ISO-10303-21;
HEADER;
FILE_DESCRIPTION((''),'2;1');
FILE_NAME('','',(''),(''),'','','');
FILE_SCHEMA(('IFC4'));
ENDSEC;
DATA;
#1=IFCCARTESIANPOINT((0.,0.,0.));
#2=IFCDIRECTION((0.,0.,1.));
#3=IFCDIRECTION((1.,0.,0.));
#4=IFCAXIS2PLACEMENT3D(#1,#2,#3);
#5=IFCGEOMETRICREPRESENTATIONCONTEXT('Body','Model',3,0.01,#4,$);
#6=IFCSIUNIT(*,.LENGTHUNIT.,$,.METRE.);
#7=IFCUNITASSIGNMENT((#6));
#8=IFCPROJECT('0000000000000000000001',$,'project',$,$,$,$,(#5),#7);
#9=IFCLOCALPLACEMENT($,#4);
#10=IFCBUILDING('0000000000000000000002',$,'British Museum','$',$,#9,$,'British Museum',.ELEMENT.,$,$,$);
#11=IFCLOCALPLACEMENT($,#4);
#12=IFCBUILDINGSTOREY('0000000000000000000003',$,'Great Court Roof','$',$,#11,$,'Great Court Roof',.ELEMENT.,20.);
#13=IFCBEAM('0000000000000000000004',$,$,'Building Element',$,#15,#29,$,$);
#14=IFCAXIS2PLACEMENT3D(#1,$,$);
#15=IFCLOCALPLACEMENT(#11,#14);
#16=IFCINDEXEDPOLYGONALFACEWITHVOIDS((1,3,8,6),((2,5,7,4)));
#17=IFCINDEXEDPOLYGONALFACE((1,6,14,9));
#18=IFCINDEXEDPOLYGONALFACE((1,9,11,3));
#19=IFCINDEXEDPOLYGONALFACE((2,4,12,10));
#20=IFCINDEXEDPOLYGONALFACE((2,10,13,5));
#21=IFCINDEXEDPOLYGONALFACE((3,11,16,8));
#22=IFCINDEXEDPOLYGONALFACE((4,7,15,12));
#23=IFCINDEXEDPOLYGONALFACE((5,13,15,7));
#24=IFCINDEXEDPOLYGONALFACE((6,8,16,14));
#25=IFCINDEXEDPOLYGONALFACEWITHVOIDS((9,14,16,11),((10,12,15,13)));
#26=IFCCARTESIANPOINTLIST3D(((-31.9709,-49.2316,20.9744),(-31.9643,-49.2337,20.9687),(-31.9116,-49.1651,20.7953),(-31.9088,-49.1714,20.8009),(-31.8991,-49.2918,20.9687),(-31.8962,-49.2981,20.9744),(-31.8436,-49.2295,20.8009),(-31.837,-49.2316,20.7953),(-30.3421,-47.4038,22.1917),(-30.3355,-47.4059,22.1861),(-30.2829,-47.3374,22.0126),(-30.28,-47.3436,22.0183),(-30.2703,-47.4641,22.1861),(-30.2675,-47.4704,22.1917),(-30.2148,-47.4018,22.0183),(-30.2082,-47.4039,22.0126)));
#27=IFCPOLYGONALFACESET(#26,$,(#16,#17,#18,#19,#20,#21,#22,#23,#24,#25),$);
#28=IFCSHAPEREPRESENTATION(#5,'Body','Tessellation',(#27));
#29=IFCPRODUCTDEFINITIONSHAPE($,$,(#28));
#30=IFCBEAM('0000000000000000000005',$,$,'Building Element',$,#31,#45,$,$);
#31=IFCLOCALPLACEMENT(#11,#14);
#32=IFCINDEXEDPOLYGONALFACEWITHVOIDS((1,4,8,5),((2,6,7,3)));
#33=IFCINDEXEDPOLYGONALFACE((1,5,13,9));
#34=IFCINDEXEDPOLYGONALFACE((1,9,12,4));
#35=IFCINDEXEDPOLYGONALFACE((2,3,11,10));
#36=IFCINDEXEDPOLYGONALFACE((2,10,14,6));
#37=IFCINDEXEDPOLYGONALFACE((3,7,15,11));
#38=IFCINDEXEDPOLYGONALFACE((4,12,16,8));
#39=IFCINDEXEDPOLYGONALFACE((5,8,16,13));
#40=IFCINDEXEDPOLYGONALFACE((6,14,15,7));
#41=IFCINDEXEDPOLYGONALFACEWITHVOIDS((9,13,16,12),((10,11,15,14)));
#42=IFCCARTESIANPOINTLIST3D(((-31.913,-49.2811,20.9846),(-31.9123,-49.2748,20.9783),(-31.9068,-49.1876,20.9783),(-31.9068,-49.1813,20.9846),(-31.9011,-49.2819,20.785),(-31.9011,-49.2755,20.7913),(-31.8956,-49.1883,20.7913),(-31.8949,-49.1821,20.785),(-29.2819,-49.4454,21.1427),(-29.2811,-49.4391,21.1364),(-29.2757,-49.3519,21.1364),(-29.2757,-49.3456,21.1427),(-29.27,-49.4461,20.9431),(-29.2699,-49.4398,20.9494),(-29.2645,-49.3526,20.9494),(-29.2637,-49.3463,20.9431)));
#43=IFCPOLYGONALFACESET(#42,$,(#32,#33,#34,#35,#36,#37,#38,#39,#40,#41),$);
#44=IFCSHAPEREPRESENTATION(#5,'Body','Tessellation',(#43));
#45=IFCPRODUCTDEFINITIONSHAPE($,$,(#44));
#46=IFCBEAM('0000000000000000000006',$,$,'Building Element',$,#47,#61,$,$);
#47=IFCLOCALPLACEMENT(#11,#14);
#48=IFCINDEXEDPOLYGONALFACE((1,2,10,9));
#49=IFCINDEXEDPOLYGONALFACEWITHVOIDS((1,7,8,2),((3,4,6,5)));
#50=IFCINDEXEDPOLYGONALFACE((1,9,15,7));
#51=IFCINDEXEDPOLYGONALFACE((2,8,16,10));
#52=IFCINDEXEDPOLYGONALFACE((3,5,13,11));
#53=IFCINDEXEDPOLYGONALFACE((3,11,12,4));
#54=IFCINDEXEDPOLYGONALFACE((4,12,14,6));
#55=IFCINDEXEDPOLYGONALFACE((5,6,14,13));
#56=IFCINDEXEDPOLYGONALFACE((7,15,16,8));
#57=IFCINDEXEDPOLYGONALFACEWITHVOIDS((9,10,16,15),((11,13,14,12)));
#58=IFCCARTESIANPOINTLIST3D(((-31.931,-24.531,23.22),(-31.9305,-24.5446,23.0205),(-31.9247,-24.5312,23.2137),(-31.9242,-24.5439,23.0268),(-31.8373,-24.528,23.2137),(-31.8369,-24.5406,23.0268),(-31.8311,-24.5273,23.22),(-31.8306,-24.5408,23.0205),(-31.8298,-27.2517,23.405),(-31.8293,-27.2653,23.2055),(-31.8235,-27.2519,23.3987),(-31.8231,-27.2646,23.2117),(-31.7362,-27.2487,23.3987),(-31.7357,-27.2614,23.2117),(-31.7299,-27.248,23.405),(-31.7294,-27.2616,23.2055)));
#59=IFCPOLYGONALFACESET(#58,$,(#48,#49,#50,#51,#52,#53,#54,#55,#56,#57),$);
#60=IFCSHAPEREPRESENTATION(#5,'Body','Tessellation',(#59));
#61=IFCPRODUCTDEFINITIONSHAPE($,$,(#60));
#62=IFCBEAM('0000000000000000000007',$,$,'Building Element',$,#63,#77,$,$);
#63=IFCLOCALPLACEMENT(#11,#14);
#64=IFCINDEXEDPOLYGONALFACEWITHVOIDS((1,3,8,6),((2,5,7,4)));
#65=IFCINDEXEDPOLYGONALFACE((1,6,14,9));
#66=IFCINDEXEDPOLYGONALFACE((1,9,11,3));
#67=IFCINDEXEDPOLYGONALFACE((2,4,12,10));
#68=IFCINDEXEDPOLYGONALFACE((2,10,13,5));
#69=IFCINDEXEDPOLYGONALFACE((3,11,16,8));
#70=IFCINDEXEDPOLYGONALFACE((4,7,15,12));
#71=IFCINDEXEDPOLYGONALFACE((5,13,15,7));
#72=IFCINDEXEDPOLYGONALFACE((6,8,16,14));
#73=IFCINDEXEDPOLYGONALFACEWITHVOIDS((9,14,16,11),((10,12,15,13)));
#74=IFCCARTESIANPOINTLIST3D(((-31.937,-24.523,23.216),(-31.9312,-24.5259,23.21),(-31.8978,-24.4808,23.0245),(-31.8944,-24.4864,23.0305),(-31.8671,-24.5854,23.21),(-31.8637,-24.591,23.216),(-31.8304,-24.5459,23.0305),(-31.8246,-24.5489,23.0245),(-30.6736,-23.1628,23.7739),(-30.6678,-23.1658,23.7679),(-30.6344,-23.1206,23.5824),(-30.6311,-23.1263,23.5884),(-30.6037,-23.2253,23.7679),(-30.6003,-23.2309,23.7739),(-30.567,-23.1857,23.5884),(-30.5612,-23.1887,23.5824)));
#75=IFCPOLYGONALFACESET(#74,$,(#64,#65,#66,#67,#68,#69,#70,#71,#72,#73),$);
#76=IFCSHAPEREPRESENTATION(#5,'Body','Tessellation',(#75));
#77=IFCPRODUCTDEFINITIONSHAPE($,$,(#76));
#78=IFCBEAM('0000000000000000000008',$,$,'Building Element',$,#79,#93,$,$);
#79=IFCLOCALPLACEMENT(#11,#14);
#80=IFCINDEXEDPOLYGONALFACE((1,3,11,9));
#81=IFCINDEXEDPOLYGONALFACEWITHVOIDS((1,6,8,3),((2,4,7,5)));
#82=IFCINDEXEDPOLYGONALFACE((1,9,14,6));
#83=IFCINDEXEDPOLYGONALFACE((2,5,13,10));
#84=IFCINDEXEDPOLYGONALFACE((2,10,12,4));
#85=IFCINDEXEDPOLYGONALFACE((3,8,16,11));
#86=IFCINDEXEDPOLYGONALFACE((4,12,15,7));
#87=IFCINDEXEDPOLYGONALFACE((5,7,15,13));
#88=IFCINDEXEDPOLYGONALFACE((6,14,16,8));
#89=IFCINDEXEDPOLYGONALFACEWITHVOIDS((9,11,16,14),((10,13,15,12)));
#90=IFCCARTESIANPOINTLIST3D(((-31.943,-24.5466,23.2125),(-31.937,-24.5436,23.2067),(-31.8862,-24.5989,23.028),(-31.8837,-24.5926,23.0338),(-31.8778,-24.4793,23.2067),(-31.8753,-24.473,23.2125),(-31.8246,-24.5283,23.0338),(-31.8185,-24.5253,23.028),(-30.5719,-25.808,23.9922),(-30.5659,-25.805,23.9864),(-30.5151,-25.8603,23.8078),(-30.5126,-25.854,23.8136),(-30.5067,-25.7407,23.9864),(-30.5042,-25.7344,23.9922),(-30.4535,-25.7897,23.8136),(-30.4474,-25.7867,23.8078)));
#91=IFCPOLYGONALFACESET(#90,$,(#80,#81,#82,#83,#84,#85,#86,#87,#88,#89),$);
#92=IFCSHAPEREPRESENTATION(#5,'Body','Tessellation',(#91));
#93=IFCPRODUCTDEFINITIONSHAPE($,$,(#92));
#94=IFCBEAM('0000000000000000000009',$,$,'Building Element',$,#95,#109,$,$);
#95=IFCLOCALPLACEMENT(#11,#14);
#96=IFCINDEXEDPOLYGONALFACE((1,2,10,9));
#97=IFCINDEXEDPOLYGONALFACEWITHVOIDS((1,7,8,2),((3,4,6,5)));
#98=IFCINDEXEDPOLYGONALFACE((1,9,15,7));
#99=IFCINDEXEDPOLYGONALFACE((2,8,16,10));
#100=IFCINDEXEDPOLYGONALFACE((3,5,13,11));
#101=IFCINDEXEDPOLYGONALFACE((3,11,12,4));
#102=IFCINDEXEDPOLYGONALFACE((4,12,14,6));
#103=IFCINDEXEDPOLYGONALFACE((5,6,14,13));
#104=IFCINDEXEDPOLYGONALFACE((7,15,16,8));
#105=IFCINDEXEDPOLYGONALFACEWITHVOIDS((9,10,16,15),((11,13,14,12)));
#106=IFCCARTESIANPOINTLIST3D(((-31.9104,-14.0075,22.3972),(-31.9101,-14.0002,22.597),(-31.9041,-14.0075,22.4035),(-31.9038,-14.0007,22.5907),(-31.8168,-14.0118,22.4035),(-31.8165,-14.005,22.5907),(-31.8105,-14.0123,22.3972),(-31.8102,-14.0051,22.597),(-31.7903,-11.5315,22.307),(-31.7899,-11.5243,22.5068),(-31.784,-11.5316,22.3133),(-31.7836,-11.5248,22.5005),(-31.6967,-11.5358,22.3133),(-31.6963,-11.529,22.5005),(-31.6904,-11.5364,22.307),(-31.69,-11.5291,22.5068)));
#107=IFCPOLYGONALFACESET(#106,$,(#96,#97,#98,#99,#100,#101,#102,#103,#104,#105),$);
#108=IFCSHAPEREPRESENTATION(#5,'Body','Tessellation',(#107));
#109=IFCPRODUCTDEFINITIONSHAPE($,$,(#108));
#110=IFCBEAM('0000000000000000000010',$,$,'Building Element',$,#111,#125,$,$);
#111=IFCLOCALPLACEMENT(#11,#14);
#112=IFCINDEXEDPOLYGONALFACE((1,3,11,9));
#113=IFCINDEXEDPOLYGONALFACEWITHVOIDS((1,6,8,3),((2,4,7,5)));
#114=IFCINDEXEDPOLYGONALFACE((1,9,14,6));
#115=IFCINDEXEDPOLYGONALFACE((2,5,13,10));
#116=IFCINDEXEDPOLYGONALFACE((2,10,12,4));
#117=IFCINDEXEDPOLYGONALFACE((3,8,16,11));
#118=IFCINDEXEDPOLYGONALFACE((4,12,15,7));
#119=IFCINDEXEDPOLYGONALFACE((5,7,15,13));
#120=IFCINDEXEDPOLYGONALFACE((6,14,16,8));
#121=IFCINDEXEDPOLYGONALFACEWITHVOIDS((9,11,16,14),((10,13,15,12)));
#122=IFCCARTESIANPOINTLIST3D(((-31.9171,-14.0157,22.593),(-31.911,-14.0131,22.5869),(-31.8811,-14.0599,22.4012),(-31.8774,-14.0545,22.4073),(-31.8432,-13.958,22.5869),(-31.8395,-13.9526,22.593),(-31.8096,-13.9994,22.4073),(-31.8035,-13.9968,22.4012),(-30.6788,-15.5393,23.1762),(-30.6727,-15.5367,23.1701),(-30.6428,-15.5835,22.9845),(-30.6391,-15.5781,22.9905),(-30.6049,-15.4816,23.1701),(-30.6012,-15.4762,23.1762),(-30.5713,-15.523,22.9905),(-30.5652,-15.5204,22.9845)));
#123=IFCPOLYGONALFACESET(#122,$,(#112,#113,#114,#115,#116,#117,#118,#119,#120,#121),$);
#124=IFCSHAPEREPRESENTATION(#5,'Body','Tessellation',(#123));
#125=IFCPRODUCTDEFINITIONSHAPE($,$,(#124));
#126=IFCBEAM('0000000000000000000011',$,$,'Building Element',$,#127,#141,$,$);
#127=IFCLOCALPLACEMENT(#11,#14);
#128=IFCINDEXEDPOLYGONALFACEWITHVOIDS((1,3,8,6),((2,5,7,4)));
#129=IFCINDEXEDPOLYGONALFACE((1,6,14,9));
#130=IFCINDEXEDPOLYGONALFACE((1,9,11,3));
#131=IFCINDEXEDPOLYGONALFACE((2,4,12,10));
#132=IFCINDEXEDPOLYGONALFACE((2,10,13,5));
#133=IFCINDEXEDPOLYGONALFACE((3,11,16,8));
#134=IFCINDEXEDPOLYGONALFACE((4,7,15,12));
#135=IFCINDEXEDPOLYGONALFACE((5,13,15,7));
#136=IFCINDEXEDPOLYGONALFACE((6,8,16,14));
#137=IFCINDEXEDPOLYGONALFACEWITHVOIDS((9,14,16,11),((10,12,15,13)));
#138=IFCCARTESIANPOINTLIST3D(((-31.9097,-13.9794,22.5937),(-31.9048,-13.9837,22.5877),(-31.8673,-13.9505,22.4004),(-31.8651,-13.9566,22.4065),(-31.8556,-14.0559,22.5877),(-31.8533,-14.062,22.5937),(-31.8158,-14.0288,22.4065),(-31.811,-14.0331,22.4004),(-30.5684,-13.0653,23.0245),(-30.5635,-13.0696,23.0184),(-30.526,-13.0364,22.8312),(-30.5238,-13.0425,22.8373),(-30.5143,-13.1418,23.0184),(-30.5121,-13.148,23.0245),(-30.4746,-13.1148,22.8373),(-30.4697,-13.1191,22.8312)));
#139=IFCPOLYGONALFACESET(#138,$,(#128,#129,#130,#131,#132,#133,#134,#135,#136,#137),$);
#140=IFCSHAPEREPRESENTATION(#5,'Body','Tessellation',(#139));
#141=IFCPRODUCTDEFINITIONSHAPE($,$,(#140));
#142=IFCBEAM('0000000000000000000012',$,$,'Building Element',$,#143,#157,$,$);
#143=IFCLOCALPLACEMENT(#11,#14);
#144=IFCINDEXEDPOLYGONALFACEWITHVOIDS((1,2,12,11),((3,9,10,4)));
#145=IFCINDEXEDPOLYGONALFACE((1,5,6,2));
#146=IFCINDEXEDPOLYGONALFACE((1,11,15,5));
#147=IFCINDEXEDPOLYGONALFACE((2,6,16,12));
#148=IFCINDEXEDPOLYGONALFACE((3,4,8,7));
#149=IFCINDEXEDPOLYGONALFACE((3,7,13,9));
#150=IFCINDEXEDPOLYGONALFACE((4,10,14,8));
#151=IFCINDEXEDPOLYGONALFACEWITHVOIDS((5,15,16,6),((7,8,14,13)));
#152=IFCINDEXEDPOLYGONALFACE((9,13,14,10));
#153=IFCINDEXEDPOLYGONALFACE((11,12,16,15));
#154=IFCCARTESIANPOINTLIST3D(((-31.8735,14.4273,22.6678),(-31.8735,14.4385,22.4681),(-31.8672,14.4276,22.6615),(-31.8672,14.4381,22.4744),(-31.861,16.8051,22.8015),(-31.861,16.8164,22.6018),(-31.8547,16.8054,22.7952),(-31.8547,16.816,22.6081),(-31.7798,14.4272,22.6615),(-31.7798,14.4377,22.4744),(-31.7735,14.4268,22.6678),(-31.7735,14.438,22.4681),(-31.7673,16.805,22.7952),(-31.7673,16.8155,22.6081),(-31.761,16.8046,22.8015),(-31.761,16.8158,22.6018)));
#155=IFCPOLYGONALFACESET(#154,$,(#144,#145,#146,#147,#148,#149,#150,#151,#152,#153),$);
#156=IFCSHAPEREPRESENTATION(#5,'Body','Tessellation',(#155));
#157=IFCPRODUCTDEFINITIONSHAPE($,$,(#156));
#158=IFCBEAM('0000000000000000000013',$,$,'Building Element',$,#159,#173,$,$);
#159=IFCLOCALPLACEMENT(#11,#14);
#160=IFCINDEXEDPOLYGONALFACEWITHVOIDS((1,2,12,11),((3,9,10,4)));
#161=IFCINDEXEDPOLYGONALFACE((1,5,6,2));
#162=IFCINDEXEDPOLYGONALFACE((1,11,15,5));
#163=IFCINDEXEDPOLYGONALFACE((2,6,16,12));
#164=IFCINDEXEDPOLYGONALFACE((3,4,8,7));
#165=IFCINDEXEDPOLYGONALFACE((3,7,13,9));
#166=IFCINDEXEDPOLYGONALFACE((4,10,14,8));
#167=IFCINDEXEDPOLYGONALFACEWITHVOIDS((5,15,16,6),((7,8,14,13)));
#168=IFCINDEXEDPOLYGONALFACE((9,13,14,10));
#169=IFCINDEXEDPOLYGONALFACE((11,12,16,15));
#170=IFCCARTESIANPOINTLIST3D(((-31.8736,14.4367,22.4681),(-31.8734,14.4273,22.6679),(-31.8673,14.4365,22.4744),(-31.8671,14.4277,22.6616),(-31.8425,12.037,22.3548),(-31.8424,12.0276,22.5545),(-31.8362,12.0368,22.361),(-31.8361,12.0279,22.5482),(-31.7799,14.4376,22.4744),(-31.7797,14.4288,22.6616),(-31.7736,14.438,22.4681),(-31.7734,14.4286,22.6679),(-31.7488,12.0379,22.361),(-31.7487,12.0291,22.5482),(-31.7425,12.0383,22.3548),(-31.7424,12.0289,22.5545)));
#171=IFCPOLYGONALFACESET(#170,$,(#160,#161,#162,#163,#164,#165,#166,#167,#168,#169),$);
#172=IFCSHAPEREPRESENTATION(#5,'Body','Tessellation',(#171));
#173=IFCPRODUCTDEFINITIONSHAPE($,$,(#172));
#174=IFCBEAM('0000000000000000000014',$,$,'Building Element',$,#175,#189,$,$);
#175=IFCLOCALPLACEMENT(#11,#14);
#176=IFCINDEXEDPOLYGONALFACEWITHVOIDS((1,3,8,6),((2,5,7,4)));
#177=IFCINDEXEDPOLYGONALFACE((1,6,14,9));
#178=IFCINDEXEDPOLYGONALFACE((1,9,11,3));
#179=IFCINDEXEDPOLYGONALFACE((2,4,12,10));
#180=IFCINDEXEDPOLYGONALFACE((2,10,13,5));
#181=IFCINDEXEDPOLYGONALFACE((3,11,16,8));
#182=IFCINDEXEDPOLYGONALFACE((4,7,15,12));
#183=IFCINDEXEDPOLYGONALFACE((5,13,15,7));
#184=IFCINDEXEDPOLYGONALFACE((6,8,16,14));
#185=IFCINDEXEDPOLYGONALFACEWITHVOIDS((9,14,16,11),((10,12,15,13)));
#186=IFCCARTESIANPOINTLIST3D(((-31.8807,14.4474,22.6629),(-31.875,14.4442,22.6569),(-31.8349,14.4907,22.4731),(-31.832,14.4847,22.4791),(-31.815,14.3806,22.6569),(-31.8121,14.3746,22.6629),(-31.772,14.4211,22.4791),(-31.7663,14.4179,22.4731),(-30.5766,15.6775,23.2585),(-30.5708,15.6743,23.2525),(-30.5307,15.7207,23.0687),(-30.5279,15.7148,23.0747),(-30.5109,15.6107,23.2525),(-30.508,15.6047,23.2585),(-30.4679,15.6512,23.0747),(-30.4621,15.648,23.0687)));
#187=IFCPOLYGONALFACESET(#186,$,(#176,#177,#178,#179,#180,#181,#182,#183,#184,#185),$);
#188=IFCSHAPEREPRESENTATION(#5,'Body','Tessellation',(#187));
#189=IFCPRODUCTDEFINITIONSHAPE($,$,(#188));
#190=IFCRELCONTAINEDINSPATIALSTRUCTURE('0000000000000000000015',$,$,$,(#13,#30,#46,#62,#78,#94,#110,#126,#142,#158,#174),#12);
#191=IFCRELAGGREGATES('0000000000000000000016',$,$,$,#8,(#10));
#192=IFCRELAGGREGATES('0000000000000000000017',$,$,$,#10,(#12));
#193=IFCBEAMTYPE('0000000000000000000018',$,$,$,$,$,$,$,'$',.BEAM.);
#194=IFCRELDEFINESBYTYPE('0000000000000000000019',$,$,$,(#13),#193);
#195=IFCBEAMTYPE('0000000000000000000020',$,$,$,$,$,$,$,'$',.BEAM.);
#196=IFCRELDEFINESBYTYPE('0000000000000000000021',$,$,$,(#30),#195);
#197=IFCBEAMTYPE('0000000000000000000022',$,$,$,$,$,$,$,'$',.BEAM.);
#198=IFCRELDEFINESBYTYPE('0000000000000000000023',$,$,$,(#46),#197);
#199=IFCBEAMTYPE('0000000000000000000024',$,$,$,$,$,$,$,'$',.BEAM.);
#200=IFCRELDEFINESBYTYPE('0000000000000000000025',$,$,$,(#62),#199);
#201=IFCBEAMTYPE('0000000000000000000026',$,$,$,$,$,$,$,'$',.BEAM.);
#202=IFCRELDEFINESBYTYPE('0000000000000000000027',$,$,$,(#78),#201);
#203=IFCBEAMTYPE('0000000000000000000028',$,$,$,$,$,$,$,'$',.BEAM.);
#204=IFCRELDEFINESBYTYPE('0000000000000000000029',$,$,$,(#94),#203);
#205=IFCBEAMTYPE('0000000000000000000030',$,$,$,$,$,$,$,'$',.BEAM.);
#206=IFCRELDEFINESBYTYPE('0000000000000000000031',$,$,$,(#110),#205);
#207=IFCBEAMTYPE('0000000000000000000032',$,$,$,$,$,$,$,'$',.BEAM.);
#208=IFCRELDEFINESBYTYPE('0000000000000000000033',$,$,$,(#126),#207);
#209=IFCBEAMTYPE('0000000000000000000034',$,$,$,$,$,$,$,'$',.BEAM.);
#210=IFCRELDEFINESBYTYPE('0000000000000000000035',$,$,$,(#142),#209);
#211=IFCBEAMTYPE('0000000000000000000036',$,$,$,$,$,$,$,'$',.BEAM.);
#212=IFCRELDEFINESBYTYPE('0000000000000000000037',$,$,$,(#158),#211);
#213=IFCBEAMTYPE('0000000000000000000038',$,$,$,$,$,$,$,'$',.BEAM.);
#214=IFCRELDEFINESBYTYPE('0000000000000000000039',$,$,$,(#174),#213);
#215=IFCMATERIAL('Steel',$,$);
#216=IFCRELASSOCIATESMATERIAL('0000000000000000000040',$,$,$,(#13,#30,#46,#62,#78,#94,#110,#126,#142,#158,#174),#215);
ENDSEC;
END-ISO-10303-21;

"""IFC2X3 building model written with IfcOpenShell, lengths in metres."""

from ifc_helpers import new_model, si_unit, frame, origin_with_axes, origin_2d, place, context, project, spatial, hollow_rectangle, extrude, material, type_object, element, save


model = new_model("IFC2X3")

# Units and contexts
model_context = context("Model", 3, precision=0.01, world=origin_with_axes(), identifier="Body")
ifc_project = project(units=[si_unit("LENGTHUNIT", "METRE")], contexts=[model_context])

# Building, storey
building_placement = place(None, origin_with_axes())
building = spatial("IfcBuilding", under=ifc_project, at=building_placement, Name="British Museum", Description="$", LongName="British Museum", CompositionType="ELEMENT")
storey_placement = place(None, origin_with_axes())
storey = spatial("IfcBuildingStorey", under=building, at=storey_placement, Name="Great Court Roof", Description="$", LongName="Great Court Roof", CompositionType="ELEMENT", Elevation=20.0)

# Beams
ifc_material = material(Name="Steel")
beam_type_1 = type_object("IfcBeamType", ElementType="$", PredefinedType="BEAM")
beam_1_placement = place(None, origin_with_axes())
element("IfcBeam", 1, at=beam_1_placement, inside=storey, type_object=beam_type_1, material=ifc_material, Description="Building Element", context=model_context, shape_type="SweptSolid", body=[
    extrude(hollow_rectangle(XDim=0.1, YDim=0.2, WallThickness=0.0063, InnerFilletRadius=-0.0063, OuterFilletRadius=0.0, at=origin_2d()), frame((-31.9039, -49.2316, 20.8848), z_axis=(0.59572, 0.668486, 0.445247), x_axis=(-0.746571, 0.665305, 0.0)), (0.0, 0.0, 1.0), 2.7341),
])
beam_type_2 = type_object("IfcBeamType", ElementType="$", PredefinedType="BEAM")
beam_2_placement = place(None, origin_with_axes())
element("IfcBeam", 2, at=beam_2_placement, inside=storey, type_object=beam_type_2, material=ifc_material, Description="Building Element", context=model_context, shape_type="SweptSolid", body=[
    extrude(hollow_rectangle(XDim=0.1, YDim=0.2, WallThickness=0.0063, InnerFilletRadius=-0.0063, OuterFilletRadius=0.0, at=origin_2d()), frame((-31.9039, -49.2316, 20.8848), z_axis=(0.996267, -0.062198, 0.059855), x_axis=(0.06231, 0.998057, 0.0)), (0.0, 0.0, 1.0), 2.641),
])
beam_type_3 = type_object("IfcBeamType", ElementType="$", PredefinedType="BEAM")
beam_3_placement = place(None, origin_with_axes())
element("IfcBeam", 3, at=beam_3_placement, inside=storey, type_object=beam_type_3, material=ifc_material, Description="Building Element", context=model_context, shape_type="SweptSolid", body=[
    extrude(hollow_rectangle(XDim=0.1, YDim=0.2, WallThickness=0.0063, InnerFilletRadius=-0.0063, OuterFilletRadius=0.0, at=origin_2d()), frame((-31.8808, -24.5359, 23.1202), z_axis=(0.037067, -0.997011, 0.067788), x_axis=(0.99931, 0.037152, 0.0)), (0.0, 0.0, 1.0), 2.7289),
])
beam_type_4 = type_object("IfcBeamType", ElementType="$", PredefinedType="BEAM")
beam_4_placement = place(None, origin_with_axes())
element("IfcBeam", 4, at=beam_4_placement, inside=storey, type_object=beam_type_4, material=ifc_material, Description="Building Element", context=model_context, shape_type="SweptSolid", body=[
    extrude(hollow_rectangle(XDim=0.1, YDim=0.2, WallThickness=0.0063, InnerFilletRadius=-0.0063, OuterFilletRadius=0.0, at=origin_2d()), frame((-31.8808, -24.5359, 23.1202), z_axis=(0.651761, 0.701689, 0.28782), x_axis=(-0.732693, 0.680559, 0.0)), (0.0, 0.0, 1.0), 1.9384),
])
beam_type_5 = type_object("IfcBeamType", ElementType="$", PredefinedType="BEAM")
beam_5_placement = place(None, origin_with_axes())
element("IfcBeam", 5, at=beam_5_placement, inside=storey, type_object=beam_type_5, material=ifc_material, Description="Building Element", context=model_context, shape_type="SweptSolid", body=[
    extrude(hollow_rectangle(XDim=0.1, YDim=0.2, WallThickness=0.0063, InnerFilletRadius=-0.0063, OuterFilletRadius=0.0, at=origin_2d()), frame((-31.8808, -24.5359, 23.1202), z_axis=(0.678878, -0.624555, 0.386078), x_axis=(0.677049, 0.735938, 0.0)), (0.0, 0.0, 1.0), 2.0197),
])
beam_type_6 = type_object("IfcBeamType", ElementType="$", PredefinedType="BEAM")
beam_6_placement = place(None, origin_with_axes())
element("IfcBeam", 6, at=beam_6_placement, inside=storey, type_object=beam_type_6, material=ifc_material, Description="Building Element", context=model_context, shape_type="SweptSolid", body=[
    extrude(hollow_rectangle(XDim=0.1, YDim=0.2, WallThickness=0.0063, InnerFilletRadius=-0.0063, OuterFilletRadius=0.0, at=origin_2d()), frame((-31.8603, -14.0063, 22.4971), z_axis=(0.048446, 0.998164, -0.036359), x_axis=(-0.998824, 0.048479, 0.0)), (0.0, 0.0, 1.0), 2.4805),
])
beam_type_7 = type_object("IfcBeamType", ElementType="$", PredefinedType="BEAM")
beam_7_placement = place(None, origin_with_axes())
element("IfcBeam", 7, at=beam_7_placement, inside=storey, type_object=beam_type_7, material=ifc_material, Description="Building Element", context=model_context, shape_type="SweptSolid", body=[
    extrude(hollow_rectangle(XDim=0.1, YDim=0.2, WallThickness=0.0063, InnerFilletRadius=-0.0063, OuterFilletRadius=0.0, at=origin_2d()), frame((-31.8603, -14.0063, 22.4971), z_axis=(0.604597, -0.74389, 0.284762), x_axis=(0.776019, 0.63071, 0.0)), (0.0, 0.0, 1.0), 2.0481),
])
beam_type_8 = type_object("IfcBeamType", ElementType="$", PredefinedType="BEAM")
beam_8_placement = place(None, origin_with_axes())
element("IfcBeam", 8, at=beam_8_placement, inside=storey, type_object=beam_type_8, material=ifc_material, Description="Building Element", context=model_context, shape_type="SweptSolid", body=[
    extrude(hollow_rectangle(XDim=0.1, YDim=0.2, WallThickness=0.0063, InnerFilletRadius=-0.0063, OuterFilletRadius=0.0, at=origin_2d()), frame((-31.8603, -14.0063, 22.4971), z_axis=(0.798701, 0.54432, 0.2565), x_axis=(-0.563161, 0.826347, 0.0)), (0.0, 0.0, 1.0), 1.6793),
])
beam_type_9 = type_object("IfcBeamType", ElementType="$", PredefinedType="BEAM")
beam_9_placement = place(None, origin_with_axes())
element("IfcBeam", 9, at=beam_9_placement, inside=storey, type_object=beam_type_9, material=ifc_material, Description="Building Element", context=model_context, shape_type="SweptSolid", body=[
    extrude(hollow_rectangle(XDim=0.1, YDim=0.2, WallThickness=0.0063, InnerFilletRadius=-0.0063, OuterFilletRadius=0.0, at=origin_2d()), frame((-31.8235, 14.4327, 22.568), z_axis=(0.005247, 0.99841, 0.056132), x_axis=(-0.999986, 0.005256, 0.0)), (0.0, 0.0, 1.0), 2.3816),
])
beam_type_10 = type_object("IfcBeamType", ElementType="$", PredefinedType="BEAM")
beam_10_placement = place(None, origin_with_axes())
element("IfcBeam", 10, at=beam_10_placement, inside=storey, type_object=beam_type_10, material=ifc_material, Description="Building Element", context=model_context, shape_type="SweptSolid", body=[
    extrude(hollow_rectangle(XDim=0.1, YDim=0.2, WallThickness=0.0063, InnerFilletRadius=-0.0063, OuterFilletRadius=0.0, at=origin_2d()), frame((-31.8235, 14.4327, 22.568), z_axis=(0.012916, -0.998803, -0.047173), x_axis=(0.999916, 0.012931, 0.0)), (0.0, 0.0, 1.0), 2.4026),
])
beam_type_11 = type_object("IfcBeamType", ElementType="$", PredefinedType="BEAM")
beam_11_placement = place(None, origin_with_axes())
element("IfcBeam", 11, at=beam_11_placement, inside=storey, type_object=beam_type_11, material=ifc_material, Description="Building Element", context=model_context, shape_type="SweptSolid", body=[
    extrude(hollow_rectangle(XDim=0.1, YDim=0.2, WallThickness=0.0063, InnerFilletRadius=-0.0063, OuterFilletRadius=0.0, at=origin_2d()), frame((-31.8235, 14.4327, 22.568), z_axis=(0.690351, 0.651154, 0.315301), x_axis=(-0.686153, 0.727457, 0.0)), (0.0, 0.0, 1.0), 1.8891),
])

save(model, "model.ifc")
